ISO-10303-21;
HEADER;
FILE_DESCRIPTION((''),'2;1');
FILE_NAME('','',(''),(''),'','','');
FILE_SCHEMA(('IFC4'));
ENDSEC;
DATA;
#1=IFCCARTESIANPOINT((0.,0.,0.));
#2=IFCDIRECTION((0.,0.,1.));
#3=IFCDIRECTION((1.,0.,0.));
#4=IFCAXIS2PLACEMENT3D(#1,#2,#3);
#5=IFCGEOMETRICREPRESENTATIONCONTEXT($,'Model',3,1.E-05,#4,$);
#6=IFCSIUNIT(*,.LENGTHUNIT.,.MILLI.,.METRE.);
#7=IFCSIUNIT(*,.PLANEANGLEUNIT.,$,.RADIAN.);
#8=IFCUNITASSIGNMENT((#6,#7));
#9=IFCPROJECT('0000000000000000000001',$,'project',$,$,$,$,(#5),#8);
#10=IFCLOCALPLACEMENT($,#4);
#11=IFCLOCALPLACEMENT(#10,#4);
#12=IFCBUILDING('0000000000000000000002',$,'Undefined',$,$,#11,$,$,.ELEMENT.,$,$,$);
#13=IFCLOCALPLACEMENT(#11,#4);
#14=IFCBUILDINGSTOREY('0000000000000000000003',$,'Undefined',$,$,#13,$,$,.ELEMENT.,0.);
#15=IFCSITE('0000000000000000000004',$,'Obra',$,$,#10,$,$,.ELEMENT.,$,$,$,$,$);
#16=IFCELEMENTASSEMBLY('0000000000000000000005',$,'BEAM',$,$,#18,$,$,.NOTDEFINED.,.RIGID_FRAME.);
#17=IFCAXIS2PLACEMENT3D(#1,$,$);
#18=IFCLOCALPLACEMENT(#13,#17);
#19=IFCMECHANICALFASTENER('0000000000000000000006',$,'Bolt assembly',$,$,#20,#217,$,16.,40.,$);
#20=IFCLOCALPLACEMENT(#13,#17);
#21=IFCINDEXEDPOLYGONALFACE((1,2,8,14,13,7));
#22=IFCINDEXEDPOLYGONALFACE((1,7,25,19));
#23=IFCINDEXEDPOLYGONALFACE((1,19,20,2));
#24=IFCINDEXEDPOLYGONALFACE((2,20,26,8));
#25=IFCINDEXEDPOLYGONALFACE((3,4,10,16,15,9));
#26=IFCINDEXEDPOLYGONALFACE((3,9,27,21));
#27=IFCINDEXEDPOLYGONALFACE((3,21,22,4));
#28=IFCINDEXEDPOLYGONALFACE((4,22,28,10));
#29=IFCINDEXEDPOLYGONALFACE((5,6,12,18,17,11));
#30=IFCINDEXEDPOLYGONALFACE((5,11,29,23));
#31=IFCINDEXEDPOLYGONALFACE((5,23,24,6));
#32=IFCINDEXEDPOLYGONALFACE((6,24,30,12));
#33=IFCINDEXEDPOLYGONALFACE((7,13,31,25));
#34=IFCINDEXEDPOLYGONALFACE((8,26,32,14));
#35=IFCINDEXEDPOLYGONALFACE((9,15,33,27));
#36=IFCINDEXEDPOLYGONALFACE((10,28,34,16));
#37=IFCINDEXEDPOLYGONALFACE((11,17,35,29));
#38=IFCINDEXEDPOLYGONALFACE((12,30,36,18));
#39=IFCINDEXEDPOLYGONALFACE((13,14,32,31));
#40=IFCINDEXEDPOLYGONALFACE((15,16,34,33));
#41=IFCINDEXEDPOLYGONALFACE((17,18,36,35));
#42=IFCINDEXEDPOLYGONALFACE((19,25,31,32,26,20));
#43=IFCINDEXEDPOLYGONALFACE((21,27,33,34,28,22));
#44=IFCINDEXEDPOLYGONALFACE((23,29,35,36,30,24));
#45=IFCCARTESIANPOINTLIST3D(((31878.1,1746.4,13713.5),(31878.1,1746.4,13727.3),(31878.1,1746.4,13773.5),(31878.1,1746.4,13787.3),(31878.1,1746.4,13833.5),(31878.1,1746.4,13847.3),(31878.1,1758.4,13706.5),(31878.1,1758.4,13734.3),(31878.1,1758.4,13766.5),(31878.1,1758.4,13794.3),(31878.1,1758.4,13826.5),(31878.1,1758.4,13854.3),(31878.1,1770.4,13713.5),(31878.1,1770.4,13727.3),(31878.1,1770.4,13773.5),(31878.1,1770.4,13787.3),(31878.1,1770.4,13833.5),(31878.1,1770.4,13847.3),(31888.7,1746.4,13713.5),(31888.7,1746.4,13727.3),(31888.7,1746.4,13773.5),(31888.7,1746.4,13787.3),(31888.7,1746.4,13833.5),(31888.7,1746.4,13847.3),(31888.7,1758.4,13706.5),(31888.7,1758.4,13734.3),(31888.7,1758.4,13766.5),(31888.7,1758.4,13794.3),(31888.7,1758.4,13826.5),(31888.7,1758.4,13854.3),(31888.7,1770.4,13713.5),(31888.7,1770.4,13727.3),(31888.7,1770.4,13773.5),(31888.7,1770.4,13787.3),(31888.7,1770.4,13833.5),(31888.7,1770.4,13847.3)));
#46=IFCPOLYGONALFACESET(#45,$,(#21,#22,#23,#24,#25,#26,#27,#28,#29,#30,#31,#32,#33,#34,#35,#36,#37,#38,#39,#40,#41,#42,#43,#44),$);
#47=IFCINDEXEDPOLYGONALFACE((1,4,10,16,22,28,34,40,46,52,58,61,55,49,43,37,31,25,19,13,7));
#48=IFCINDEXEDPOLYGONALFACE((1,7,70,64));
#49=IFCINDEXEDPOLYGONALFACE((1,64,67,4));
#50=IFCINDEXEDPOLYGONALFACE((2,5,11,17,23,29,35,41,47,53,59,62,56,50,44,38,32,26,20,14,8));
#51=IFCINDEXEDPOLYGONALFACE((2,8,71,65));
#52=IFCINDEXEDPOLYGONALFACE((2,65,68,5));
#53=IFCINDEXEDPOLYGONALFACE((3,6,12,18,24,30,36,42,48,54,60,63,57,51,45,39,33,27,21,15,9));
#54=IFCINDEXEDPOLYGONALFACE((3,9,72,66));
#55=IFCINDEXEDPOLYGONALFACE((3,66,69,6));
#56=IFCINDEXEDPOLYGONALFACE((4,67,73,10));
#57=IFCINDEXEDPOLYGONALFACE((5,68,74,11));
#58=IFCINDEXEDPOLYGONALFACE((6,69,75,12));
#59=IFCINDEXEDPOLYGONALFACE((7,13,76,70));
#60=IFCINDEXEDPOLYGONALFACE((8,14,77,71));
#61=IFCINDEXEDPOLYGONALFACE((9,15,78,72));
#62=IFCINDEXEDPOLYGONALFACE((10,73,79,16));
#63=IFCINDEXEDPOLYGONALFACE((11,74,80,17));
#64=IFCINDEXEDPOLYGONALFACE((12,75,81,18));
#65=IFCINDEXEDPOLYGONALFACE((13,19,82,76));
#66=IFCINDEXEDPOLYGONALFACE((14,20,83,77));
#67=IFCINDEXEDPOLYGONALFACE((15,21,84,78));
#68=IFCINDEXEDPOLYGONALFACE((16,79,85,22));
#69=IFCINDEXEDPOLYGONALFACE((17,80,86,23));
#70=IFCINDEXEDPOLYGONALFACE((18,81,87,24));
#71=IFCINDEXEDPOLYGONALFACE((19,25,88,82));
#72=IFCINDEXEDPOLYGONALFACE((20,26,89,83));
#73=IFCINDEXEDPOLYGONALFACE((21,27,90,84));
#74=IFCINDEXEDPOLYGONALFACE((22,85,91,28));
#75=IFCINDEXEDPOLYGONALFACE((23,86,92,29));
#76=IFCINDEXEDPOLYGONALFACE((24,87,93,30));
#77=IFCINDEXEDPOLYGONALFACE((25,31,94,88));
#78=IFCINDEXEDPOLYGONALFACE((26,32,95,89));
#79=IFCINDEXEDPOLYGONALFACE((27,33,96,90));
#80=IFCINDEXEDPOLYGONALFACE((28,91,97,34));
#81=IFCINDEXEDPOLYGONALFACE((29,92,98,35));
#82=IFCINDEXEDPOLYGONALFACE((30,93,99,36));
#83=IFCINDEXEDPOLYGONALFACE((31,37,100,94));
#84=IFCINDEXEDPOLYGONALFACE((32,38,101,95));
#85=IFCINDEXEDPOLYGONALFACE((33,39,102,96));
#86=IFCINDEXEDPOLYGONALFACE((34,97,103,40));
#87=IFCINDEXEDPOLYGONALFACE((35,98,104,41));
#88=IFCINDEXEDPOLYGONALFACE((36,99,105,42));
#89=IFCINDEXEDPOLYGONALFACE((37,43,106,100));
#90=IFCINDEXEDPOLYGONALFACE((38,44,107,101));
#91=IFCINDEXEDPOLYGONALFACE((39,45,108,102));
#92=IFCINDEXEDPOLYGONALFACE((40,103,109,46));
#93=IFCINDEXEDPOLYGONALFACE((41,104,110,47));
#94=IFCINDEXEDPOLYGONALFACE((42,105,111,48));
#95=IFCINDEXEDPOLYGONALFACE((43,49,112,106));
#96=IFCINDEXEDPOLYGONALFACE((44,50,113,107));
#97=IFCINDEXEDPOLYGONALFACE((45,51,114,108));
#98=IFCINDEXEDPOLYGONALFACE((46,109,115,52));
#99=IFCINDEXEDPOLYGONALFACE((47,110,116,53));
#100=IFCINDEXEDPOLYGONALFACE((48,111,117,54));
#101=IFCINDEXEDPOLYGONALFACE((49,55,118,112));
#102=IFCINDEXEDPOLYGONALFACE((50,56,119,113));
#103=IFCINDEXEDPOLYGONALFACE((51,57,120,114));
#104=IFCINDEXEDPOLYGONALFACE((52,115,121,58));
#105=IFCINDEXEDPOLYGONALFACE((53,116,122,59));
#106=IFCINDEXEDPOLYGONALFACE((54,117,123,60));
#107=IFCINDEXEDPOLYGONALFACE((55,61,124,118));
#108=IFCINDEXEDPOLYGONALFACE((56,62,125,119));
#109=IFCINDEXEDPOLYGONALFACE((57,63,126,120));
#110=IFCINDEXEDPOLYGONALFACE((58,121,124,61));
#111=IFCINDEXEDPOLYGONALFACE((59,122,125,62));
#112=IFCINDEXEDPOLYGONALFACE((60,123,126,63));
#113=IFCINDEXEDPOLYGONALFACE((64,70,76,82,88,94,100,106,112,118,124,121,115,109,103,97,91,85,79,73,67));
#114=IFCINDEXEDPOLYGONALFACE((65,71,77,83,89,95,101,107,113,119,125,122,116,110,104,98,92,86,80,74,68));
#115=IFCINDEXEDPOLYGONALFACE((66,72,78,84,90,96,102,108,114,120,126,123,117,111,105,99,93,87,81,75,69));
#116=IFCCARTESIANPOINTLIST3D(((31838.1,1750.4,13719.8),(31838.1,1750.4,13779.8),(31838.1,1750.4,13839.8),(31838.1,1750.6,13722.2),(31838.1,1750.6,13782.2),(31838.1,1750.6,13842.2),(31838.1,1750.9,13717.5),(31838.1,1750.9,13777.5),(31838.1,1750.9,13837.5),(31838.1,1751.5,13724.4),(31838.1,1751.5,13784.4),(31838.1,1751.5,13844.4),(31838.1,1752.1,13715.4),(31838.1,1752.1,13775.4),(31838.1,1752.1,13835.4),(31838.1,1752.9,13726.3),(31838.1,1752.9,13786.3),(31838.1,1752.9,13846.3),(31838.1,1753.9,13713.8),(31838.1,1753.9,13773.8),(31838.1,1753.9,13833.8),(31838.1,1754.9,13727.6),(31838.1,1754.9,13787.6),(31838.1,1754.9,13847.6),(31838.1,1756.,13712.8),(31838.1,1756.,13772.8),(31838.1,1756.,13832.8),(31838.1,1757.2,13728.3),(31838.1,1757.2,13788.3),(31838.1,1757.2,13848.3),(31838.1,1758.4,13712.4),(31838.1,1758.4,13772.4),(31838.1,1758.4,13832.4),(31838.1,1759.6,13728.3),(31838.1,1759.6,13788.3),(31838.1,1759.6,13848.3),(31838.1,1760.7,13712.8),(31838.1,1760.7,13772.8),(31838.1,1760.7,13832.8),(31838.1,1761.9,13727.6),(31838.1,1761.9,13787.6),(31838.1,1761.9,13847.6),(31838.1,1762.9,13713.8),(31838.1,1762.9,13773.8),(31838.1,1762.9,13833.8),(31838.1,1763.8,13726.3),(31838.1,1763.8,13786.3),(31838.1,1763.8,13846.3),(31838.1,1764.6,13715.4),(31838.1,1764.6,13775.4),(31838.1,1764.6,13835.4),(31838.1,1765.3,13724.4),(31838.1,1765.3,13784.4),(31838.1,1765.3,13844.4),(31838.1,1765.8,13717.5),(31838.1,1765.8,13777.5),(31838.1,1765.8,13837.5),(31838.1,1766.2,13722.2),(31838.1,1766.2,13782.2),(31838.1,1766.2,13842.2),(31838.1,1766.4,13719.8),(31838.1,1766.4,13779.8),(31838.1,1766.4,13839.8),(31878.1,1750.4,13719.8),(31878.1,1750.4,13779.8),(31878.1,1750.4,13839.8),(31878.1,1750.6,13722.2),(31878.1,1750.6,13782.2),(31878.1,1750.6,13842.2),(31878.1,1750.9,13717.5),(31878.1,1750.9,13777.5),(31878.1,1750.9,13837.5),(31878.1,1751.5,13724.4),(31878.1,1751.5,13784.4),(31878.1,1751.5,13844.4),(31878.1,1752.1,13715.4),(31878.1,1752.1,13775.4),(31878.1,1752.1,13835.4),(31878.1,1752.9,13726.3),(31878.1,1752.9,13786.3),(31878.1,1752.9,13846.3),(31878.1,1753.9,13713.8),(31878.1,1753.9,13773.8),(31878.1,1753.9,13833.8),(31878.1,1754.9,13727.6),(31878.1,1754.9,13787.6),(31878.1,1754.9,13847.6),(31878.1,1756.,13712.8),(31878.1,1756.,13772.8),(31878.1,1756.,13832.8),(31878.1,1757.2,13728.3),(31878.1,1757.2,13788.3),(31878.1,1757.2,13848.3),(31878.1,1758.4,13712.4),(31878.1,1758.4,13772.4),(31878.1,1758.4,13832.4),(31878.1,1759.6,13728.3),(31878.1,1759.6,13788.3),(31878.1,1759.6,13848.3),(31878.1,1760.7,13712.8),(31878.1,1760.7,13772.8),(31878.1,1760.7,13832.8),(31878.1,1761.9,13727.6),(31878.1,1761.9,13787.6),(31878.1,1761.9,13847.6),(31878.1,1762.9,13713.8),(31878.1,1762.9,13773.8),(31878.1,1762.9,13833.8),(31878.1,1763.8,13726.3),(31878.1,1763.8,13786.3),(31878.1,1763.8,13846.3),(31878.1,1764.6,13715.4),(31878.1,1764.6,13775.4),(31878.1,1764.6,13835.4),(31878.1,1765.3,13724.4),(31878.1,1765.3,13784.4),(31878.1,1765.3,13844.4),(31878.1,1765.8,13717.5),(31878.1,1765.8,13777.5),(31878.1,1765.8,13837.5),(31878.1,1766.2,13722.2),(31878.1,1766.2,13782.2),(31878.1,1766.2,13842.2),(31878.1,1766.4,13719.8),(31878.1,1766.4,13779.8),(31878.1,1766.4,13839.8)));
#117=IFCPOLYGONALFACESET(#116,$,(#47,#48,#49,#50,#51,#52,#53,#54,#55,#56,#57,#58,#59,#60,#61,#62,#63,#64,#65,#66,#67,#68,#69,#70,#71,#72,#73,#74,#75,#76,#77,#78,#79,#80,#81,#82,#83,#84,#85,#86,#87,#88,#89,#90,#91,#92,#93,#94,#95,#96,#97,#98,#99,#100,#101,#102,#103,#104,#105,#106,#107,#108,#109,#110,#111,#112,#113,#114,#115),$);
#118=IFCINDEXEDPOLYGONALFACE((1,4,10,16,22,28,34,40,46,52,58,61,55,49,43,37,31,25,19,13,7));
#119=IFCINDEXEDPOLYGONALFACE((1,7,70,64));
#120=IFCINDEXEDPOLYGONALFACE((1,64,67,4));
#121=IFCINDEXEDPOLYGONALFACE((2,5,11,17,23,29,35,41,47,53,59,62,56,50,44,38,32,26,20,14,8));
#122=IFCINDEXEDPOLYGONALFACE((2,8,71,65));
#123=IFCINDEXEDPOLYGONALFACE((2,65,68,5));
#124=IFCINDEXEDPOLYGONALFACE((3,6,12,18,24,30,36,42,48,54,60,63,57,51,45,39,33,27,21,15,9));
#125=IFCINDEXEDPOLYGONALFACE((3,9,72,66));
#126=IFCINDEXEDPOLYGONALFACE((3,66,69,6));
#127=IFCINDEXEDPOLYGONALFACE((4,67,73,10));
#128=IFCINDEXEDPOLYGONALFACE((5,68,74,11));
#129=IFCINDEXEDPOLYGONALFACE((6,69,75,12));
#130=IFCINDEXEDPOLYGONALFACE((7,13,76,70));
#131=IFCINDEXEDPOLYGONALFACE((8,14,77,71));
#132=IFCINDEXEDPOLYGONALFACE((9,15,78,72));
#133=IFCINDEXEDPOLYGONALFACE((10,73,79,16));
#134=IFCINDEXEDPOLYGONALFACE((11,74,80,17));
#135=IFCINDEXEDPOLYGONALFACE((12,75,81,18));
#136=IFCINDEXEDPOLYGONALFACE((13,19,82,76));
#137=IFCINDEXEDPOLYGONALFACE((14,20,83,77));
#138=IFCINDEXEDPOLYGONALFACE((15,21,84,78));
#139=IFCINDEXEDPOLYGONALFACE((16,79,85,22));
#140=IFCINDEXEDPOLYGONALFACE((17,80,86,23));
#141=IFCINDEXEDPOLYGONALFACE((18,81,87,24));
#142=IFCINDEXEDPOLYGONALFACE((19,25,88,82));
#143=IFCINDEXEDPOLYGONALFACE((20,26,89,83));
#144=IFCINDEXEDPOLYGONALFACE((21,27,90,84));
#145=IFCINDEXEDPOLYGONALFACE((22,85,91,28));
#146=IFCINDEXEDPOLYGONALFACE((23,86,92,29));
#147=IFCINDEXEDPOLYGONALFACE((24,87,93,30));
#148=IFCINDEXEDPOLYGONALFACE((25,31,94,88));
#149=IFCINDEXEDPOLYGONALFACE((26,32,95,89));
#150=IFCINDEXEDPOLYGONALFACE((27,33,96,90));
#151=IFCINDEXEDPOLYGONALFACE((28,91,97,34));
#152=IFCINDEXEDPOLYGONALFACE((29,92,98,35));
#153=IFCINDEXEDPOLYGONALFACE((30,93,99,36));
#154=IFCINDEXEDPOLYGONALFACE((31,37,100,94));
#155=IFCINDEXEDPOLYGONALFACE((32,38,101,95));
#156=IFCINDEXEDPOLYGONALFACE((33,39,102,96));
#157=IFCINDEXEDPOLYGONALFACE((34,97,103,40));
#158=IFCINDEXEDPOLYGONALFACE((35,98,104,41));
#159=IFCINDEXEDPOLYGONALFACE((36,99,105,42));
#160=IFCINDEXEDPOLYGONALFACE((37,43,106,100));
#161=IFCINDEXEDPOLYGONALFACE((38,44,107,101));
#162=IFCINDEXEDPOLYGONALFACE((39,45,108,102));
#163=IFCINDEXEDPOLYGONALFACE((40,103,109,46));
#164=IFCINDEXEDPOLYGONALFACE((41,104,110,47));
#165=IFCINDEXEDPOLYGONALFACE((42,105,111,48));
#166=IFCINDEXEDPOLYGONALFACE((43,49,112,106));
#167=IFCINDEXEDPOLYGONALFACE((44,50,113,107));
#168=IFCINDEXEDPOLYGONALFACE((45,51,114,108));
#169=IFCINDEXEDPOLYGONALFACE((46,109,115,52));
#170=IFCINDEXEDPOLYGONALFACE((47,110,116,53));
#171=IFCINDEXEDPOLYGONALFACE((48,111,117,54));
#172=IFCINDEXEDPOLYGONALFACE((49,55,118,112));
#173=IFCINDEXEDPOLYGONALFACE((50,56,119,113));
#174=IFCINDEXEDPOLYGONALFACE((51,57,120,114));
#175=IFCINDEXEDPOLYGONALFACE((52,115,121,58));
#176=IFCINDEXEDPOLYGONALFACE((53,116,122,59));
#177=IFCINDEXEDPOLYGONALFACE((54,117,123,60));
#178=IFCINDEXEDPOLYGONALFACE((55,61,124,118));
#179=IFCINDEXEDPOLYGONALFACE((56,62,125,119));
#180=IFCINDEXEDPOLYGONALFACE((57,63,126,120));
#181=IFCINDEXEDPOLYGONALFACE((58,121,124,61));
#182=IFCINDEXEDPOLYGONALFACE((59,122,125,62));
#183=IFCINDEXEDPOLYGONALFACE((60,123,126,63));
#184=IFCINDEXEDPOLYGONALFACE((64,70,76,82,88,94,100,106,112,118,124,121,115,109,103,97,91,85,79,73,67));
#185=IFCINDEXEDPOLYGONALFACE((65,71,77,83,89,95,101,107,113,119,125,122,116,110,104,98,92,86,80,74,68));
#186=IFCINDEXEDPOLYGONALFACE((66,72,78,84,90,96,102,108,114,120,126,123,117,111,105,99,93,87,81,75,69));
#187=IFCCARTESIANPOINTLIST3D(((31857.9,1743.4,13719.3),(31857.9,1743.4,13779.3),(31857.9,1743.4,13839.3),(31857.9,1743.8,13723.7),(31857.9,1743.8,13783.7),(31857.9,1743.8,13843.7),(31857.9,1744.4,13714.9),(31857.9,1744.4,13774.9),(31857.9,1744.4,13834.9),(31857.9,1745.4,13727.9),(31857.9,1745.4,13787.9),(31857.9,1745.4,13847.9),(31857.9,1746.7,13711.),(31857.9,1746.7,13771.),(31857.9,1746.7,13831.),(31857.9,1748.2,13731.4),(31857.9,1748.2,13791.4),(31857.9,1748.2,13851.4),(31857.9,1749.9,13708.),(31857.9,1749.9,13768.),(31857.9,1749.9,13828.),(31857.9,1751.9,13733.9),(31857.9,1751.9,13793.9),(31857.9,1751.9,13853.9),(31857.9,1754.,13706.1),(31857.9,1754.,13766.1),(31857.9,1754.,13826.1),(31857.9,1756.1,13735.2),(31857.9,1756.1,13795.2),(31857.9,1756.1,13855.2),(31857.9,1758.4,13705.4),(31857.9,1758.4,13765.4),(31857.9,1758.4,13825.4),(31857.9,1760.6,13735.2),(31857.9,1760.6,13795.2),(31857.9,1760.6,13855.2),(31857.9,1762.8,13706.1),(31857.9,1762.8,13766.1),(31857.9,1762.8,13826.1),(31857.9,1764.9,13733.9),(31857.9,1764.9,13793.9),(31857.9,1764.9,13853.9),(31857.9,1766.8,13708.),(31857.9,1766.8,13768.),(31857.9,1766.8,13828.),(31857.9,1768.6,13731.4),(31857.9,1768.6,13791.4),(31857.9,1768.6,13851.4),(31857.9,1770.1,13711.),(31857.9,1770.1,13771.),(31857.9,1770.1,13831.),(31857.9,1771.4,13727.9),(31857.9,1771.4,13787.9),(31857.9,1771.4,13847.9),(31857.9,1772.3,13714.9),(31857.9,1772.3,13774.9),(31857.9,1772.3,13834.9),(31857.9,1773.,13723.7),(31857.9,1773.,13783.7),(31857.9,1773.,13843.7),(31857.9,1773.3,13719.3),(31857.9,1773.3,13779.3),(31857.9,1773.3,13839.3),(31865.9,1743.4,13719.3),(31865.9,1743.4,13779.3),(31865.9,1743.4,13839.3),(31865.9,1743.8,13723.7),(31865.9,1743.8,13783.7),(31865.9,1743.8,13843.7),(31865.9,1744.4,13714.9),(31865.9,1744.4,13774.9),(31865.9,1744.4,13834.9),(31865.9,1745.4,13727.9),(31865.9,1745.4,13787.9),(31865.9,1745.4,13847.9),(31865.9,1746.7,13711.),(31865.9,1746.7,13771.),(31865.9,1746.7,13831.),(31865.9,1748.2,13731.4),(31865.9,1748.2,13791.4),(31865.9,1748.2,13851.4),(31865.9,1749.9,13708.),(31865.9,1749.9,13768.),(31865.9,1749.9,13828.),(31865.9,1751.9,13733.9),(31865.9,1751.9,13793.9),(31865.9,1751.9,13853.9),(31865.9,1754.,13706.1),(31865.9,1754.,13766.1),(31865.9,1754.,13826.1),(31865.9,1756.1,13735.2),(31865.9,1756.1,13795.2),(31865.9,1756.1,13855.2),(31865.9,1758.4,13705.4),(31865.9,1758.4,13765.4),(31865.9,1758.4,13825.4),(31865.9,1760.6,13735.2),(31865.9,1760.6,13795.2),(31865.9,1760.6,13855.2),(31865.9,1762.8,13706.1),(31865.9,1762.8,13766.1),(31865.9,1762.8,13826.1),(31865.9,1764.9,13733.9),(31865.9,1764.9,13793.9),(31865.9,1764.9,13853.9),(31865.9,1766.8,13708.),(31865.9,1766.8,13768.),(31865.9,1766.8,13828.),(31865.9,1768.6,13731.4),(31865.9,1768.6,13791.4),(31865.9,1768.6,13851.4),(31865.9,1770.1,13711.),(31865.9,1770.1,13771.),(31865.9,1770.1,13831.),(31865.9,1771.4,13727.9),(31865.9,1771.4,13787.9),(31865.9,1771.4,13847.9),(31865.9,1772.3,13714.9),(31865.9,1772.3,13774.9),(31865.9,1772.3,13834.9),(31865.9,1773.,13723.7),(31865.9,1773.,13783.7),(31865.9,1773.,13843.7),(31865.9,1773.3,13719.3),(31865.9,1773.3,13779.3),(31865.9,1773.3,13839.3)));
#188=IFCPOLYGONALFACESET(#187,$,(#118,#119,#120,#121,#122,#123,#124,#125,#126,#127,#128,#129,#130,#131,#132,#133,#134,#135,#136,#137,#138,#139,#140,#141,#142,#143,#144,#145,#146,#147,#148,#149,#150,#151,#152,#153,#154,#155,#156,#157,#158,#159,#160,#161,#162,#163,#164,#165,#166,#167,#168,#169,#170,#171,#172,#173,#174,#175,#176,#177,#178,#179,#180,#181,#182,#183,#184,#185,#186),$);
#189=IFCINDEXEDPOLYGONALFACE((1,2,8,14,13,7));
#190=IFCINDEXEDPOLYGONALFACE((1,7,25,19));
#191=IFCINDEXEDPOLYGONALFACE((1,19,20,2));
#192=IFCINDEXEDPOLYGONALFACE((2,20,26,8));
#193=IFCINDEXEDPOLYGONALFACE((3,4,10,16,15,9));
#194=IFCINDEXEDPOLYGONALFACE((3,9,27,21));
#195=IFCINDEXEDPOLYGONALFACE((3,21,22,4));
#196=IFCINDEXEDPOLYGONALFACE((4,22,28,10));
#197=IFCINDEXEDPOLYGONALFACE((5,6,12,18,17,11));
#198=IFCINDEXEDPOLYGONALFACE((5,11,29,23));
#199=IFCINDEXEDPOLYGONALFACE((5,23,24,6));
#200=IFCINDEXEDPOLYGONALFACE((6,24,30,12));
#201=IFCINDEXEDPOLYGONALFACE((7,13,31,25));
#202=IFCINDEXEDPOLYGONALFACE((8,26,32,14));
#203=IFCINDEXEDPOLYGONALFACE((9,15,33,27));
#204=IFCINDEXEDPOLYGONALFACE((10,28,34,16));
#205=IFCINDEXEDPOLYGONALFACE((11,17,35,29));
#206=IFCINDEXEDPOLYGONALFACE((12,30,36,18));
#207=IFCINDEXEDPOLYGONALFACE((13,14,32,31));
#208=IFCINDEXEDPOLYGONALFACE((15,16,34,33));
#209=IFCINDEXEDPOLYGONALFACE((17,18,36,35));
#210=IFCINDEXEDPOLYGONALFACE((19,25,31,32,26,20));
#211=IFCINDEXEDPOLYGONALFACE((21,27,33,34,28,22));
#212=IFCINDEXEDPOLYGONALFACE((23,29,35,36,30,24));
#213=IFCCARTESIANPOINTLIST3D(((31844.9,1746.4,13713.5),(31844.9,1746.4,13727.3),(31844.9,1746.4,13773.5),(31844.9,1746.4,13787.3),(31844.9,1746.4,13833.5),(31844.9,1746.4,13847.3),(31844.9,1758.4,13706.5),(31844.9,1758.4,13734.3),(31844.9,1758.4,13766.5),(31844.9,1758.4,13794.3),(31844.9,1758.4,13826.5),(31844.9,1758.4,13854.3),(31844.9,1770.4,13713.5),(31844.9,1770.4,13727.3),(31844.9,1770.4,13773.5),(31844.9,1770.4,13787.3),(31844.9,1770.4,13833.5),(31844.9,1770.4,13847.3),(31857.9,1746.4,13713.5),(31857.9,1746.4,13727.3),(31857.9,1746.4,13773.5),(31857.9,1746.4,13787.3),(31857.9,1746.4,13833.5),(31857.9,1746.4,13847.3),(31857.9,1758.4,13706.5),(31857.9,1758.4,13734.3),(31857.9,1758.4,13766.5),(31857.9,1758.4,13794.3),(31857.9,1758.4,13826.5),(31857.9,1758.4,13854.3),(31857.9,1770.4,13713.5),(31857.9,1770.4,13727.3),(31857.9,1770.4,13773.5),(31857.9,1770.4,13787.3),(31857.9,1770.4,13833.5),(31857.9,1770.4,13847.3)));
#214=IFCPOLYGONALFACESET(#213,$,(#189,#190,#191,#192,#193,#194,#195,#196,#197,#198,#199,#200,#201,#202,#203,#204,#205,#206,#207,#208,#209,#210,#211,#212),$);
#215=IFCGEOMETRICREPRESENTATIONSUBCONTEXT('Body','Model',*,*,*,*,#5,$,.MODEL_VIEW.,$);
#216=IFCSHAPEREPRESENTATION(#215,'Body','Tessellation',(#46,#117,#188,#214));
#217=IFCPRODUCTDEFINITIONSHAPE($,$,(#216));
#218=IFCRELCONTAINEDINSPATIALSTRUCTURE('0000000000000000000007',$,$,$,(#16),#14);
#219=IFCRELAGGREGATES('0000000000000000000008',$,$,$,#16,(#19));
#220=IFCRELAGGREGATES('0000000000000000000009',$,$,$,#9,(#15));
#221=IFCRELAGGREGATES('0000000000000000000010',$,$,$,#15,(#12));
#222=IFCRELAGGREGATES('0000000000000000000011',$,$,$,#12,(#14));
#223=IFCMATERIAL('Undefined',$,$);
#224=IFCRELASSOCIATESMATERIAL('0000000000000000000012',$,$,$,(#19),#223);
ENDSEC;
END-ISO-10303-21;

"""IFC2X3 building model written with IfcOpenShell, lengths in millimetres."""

from ifc_helpers import new_model, si_unit, frame, origin_with_axes, origin_2d_with_axis, place, context, subcontext, project, spatial, polyline, circle, outline, extrude, source, transform, mapped, material, element, aggregate, save


model = new_model("IFC2X3")

# Units and contexts
model_context = context("Model", 3, precision=1e-05, world=origin_with_axes())
body_context = subcontext(model_context, "Body", "Model", "MODEL_VIEW")
ifc_project = project(units=[si_unit("LENGTHUNIT", "METRE", prefix="MILLI"), si_unit("PLANEANGLEUNIT", "RADIAN")], contexts=[model_context])

# Site, building, storey
site_placement = place(None, origin_with_axes())
site = spatial("IfcSite", under=ifc_project, at=site_placement, Name="Obra", CompositionType="ELEMENT")
building_placement = place(site_placement, origin_with_axes())
building = spatial("IfcBuilding", under=site, at=building_placement, Name="Undefined", CompositionType="ELEMENT")
storey_placement = place(building_placement, origin_with_axes())
storey = spatial("IfcBuildingStorey", under=building, at=storey_placement, Name="Undefined", CompositionType="ELEMENT", Elevation=0.0)

# Shared definitions
ifc_material_1 = material(Name="Undefined")

# Element assembly, mechanical fastener
assembly_1_placement = place(storey_placement, origin_with_axes())
assembly_1 = element("IfcElementAssembly", 1, at=assembly_1_placement, inside=storey, Name="BEAM", AssemblyPlace="NOTDEFINED", PredefinedType="RIGID_FRAME")
shared_shape_1 = source(origin_with_axes(), body_context, "Body", "SweptSolid", [
    extrude(outline(polyline([(13.9, 0.0), (6.9, 12.0), (-6.9, 12.0), (-13.9, 0.0), (-6.9, -12.0), (6.9, -12.0), (13.9, 0.0)])), frame((0.0, -13.7, 0.0), z_axis=(0.0, 1.0, 0.0), x_axis=(1.0, 0.0, 0.0)), (0.0, 0.0, 1.0), 10.6),
    extrude(circle(Radius=8.0, at=origin_2d_with_axis()), frame((0.0, -3.1, 0.0), z_axis=(0.0, 1.0, 0.0), x_axis=(1.0, 0.0, 0.0)), (0.0, 0.0, 1.0), 40.0),
    extrude(circle(Radius=15.0, at=origin_2d_with_axis()), frame((0.0, 9.1, 0.0), z_axis=(0.0, 1.0, 0.0), x_axis=(1.0, 0.0, 0.0)), (0.0, 0.0, 1.0), 8.0),
    extrude(outline(polyline([(13.9, 0.0), (6.9, 12.0), (-6.9, 12.0), (-13.9, 0.0), (-6.9, -12.0), (6.9, -12.0), (13.9, 0.0)])), frame((0.0, 17.1, 0.0), z_axis=(0.0, 1.0, 0.0), x_axis=(1.0, 0.0, 0.0)), (0.0, 0.0, 1.0), 13.0),
])
mechanical_fastener_1_placement = place(assembly_1_placement, frame((31875.0, 1708.4, 13875.4), z_axis=(0.0, 1.0, 0.0), x_axis=(0.0, 0.0, -1.0)))
mechanical_fastener_1 = element("IfcMechanicalFastener", 2, at=mechanical_fastener_1_placement, material=ifc_material_1, Name="Bolt assembly", NominalDiameter=16.0, NominalLength=40.0, context=body_context, shape_type="MappedRepresentation", body=[
    mapped(shared_shape_1, transform((35.0, 0.0, 50.0))),
    mapped(shared_shape_1, transform((95.0, 0.0, 50.0))),
    mapped(shared_shape_1, transform((155.0, 0.0, 50.0))),
])
aggregate(assembly_1, [mechanical_fastener_1])

save(model, "model.ifc")
